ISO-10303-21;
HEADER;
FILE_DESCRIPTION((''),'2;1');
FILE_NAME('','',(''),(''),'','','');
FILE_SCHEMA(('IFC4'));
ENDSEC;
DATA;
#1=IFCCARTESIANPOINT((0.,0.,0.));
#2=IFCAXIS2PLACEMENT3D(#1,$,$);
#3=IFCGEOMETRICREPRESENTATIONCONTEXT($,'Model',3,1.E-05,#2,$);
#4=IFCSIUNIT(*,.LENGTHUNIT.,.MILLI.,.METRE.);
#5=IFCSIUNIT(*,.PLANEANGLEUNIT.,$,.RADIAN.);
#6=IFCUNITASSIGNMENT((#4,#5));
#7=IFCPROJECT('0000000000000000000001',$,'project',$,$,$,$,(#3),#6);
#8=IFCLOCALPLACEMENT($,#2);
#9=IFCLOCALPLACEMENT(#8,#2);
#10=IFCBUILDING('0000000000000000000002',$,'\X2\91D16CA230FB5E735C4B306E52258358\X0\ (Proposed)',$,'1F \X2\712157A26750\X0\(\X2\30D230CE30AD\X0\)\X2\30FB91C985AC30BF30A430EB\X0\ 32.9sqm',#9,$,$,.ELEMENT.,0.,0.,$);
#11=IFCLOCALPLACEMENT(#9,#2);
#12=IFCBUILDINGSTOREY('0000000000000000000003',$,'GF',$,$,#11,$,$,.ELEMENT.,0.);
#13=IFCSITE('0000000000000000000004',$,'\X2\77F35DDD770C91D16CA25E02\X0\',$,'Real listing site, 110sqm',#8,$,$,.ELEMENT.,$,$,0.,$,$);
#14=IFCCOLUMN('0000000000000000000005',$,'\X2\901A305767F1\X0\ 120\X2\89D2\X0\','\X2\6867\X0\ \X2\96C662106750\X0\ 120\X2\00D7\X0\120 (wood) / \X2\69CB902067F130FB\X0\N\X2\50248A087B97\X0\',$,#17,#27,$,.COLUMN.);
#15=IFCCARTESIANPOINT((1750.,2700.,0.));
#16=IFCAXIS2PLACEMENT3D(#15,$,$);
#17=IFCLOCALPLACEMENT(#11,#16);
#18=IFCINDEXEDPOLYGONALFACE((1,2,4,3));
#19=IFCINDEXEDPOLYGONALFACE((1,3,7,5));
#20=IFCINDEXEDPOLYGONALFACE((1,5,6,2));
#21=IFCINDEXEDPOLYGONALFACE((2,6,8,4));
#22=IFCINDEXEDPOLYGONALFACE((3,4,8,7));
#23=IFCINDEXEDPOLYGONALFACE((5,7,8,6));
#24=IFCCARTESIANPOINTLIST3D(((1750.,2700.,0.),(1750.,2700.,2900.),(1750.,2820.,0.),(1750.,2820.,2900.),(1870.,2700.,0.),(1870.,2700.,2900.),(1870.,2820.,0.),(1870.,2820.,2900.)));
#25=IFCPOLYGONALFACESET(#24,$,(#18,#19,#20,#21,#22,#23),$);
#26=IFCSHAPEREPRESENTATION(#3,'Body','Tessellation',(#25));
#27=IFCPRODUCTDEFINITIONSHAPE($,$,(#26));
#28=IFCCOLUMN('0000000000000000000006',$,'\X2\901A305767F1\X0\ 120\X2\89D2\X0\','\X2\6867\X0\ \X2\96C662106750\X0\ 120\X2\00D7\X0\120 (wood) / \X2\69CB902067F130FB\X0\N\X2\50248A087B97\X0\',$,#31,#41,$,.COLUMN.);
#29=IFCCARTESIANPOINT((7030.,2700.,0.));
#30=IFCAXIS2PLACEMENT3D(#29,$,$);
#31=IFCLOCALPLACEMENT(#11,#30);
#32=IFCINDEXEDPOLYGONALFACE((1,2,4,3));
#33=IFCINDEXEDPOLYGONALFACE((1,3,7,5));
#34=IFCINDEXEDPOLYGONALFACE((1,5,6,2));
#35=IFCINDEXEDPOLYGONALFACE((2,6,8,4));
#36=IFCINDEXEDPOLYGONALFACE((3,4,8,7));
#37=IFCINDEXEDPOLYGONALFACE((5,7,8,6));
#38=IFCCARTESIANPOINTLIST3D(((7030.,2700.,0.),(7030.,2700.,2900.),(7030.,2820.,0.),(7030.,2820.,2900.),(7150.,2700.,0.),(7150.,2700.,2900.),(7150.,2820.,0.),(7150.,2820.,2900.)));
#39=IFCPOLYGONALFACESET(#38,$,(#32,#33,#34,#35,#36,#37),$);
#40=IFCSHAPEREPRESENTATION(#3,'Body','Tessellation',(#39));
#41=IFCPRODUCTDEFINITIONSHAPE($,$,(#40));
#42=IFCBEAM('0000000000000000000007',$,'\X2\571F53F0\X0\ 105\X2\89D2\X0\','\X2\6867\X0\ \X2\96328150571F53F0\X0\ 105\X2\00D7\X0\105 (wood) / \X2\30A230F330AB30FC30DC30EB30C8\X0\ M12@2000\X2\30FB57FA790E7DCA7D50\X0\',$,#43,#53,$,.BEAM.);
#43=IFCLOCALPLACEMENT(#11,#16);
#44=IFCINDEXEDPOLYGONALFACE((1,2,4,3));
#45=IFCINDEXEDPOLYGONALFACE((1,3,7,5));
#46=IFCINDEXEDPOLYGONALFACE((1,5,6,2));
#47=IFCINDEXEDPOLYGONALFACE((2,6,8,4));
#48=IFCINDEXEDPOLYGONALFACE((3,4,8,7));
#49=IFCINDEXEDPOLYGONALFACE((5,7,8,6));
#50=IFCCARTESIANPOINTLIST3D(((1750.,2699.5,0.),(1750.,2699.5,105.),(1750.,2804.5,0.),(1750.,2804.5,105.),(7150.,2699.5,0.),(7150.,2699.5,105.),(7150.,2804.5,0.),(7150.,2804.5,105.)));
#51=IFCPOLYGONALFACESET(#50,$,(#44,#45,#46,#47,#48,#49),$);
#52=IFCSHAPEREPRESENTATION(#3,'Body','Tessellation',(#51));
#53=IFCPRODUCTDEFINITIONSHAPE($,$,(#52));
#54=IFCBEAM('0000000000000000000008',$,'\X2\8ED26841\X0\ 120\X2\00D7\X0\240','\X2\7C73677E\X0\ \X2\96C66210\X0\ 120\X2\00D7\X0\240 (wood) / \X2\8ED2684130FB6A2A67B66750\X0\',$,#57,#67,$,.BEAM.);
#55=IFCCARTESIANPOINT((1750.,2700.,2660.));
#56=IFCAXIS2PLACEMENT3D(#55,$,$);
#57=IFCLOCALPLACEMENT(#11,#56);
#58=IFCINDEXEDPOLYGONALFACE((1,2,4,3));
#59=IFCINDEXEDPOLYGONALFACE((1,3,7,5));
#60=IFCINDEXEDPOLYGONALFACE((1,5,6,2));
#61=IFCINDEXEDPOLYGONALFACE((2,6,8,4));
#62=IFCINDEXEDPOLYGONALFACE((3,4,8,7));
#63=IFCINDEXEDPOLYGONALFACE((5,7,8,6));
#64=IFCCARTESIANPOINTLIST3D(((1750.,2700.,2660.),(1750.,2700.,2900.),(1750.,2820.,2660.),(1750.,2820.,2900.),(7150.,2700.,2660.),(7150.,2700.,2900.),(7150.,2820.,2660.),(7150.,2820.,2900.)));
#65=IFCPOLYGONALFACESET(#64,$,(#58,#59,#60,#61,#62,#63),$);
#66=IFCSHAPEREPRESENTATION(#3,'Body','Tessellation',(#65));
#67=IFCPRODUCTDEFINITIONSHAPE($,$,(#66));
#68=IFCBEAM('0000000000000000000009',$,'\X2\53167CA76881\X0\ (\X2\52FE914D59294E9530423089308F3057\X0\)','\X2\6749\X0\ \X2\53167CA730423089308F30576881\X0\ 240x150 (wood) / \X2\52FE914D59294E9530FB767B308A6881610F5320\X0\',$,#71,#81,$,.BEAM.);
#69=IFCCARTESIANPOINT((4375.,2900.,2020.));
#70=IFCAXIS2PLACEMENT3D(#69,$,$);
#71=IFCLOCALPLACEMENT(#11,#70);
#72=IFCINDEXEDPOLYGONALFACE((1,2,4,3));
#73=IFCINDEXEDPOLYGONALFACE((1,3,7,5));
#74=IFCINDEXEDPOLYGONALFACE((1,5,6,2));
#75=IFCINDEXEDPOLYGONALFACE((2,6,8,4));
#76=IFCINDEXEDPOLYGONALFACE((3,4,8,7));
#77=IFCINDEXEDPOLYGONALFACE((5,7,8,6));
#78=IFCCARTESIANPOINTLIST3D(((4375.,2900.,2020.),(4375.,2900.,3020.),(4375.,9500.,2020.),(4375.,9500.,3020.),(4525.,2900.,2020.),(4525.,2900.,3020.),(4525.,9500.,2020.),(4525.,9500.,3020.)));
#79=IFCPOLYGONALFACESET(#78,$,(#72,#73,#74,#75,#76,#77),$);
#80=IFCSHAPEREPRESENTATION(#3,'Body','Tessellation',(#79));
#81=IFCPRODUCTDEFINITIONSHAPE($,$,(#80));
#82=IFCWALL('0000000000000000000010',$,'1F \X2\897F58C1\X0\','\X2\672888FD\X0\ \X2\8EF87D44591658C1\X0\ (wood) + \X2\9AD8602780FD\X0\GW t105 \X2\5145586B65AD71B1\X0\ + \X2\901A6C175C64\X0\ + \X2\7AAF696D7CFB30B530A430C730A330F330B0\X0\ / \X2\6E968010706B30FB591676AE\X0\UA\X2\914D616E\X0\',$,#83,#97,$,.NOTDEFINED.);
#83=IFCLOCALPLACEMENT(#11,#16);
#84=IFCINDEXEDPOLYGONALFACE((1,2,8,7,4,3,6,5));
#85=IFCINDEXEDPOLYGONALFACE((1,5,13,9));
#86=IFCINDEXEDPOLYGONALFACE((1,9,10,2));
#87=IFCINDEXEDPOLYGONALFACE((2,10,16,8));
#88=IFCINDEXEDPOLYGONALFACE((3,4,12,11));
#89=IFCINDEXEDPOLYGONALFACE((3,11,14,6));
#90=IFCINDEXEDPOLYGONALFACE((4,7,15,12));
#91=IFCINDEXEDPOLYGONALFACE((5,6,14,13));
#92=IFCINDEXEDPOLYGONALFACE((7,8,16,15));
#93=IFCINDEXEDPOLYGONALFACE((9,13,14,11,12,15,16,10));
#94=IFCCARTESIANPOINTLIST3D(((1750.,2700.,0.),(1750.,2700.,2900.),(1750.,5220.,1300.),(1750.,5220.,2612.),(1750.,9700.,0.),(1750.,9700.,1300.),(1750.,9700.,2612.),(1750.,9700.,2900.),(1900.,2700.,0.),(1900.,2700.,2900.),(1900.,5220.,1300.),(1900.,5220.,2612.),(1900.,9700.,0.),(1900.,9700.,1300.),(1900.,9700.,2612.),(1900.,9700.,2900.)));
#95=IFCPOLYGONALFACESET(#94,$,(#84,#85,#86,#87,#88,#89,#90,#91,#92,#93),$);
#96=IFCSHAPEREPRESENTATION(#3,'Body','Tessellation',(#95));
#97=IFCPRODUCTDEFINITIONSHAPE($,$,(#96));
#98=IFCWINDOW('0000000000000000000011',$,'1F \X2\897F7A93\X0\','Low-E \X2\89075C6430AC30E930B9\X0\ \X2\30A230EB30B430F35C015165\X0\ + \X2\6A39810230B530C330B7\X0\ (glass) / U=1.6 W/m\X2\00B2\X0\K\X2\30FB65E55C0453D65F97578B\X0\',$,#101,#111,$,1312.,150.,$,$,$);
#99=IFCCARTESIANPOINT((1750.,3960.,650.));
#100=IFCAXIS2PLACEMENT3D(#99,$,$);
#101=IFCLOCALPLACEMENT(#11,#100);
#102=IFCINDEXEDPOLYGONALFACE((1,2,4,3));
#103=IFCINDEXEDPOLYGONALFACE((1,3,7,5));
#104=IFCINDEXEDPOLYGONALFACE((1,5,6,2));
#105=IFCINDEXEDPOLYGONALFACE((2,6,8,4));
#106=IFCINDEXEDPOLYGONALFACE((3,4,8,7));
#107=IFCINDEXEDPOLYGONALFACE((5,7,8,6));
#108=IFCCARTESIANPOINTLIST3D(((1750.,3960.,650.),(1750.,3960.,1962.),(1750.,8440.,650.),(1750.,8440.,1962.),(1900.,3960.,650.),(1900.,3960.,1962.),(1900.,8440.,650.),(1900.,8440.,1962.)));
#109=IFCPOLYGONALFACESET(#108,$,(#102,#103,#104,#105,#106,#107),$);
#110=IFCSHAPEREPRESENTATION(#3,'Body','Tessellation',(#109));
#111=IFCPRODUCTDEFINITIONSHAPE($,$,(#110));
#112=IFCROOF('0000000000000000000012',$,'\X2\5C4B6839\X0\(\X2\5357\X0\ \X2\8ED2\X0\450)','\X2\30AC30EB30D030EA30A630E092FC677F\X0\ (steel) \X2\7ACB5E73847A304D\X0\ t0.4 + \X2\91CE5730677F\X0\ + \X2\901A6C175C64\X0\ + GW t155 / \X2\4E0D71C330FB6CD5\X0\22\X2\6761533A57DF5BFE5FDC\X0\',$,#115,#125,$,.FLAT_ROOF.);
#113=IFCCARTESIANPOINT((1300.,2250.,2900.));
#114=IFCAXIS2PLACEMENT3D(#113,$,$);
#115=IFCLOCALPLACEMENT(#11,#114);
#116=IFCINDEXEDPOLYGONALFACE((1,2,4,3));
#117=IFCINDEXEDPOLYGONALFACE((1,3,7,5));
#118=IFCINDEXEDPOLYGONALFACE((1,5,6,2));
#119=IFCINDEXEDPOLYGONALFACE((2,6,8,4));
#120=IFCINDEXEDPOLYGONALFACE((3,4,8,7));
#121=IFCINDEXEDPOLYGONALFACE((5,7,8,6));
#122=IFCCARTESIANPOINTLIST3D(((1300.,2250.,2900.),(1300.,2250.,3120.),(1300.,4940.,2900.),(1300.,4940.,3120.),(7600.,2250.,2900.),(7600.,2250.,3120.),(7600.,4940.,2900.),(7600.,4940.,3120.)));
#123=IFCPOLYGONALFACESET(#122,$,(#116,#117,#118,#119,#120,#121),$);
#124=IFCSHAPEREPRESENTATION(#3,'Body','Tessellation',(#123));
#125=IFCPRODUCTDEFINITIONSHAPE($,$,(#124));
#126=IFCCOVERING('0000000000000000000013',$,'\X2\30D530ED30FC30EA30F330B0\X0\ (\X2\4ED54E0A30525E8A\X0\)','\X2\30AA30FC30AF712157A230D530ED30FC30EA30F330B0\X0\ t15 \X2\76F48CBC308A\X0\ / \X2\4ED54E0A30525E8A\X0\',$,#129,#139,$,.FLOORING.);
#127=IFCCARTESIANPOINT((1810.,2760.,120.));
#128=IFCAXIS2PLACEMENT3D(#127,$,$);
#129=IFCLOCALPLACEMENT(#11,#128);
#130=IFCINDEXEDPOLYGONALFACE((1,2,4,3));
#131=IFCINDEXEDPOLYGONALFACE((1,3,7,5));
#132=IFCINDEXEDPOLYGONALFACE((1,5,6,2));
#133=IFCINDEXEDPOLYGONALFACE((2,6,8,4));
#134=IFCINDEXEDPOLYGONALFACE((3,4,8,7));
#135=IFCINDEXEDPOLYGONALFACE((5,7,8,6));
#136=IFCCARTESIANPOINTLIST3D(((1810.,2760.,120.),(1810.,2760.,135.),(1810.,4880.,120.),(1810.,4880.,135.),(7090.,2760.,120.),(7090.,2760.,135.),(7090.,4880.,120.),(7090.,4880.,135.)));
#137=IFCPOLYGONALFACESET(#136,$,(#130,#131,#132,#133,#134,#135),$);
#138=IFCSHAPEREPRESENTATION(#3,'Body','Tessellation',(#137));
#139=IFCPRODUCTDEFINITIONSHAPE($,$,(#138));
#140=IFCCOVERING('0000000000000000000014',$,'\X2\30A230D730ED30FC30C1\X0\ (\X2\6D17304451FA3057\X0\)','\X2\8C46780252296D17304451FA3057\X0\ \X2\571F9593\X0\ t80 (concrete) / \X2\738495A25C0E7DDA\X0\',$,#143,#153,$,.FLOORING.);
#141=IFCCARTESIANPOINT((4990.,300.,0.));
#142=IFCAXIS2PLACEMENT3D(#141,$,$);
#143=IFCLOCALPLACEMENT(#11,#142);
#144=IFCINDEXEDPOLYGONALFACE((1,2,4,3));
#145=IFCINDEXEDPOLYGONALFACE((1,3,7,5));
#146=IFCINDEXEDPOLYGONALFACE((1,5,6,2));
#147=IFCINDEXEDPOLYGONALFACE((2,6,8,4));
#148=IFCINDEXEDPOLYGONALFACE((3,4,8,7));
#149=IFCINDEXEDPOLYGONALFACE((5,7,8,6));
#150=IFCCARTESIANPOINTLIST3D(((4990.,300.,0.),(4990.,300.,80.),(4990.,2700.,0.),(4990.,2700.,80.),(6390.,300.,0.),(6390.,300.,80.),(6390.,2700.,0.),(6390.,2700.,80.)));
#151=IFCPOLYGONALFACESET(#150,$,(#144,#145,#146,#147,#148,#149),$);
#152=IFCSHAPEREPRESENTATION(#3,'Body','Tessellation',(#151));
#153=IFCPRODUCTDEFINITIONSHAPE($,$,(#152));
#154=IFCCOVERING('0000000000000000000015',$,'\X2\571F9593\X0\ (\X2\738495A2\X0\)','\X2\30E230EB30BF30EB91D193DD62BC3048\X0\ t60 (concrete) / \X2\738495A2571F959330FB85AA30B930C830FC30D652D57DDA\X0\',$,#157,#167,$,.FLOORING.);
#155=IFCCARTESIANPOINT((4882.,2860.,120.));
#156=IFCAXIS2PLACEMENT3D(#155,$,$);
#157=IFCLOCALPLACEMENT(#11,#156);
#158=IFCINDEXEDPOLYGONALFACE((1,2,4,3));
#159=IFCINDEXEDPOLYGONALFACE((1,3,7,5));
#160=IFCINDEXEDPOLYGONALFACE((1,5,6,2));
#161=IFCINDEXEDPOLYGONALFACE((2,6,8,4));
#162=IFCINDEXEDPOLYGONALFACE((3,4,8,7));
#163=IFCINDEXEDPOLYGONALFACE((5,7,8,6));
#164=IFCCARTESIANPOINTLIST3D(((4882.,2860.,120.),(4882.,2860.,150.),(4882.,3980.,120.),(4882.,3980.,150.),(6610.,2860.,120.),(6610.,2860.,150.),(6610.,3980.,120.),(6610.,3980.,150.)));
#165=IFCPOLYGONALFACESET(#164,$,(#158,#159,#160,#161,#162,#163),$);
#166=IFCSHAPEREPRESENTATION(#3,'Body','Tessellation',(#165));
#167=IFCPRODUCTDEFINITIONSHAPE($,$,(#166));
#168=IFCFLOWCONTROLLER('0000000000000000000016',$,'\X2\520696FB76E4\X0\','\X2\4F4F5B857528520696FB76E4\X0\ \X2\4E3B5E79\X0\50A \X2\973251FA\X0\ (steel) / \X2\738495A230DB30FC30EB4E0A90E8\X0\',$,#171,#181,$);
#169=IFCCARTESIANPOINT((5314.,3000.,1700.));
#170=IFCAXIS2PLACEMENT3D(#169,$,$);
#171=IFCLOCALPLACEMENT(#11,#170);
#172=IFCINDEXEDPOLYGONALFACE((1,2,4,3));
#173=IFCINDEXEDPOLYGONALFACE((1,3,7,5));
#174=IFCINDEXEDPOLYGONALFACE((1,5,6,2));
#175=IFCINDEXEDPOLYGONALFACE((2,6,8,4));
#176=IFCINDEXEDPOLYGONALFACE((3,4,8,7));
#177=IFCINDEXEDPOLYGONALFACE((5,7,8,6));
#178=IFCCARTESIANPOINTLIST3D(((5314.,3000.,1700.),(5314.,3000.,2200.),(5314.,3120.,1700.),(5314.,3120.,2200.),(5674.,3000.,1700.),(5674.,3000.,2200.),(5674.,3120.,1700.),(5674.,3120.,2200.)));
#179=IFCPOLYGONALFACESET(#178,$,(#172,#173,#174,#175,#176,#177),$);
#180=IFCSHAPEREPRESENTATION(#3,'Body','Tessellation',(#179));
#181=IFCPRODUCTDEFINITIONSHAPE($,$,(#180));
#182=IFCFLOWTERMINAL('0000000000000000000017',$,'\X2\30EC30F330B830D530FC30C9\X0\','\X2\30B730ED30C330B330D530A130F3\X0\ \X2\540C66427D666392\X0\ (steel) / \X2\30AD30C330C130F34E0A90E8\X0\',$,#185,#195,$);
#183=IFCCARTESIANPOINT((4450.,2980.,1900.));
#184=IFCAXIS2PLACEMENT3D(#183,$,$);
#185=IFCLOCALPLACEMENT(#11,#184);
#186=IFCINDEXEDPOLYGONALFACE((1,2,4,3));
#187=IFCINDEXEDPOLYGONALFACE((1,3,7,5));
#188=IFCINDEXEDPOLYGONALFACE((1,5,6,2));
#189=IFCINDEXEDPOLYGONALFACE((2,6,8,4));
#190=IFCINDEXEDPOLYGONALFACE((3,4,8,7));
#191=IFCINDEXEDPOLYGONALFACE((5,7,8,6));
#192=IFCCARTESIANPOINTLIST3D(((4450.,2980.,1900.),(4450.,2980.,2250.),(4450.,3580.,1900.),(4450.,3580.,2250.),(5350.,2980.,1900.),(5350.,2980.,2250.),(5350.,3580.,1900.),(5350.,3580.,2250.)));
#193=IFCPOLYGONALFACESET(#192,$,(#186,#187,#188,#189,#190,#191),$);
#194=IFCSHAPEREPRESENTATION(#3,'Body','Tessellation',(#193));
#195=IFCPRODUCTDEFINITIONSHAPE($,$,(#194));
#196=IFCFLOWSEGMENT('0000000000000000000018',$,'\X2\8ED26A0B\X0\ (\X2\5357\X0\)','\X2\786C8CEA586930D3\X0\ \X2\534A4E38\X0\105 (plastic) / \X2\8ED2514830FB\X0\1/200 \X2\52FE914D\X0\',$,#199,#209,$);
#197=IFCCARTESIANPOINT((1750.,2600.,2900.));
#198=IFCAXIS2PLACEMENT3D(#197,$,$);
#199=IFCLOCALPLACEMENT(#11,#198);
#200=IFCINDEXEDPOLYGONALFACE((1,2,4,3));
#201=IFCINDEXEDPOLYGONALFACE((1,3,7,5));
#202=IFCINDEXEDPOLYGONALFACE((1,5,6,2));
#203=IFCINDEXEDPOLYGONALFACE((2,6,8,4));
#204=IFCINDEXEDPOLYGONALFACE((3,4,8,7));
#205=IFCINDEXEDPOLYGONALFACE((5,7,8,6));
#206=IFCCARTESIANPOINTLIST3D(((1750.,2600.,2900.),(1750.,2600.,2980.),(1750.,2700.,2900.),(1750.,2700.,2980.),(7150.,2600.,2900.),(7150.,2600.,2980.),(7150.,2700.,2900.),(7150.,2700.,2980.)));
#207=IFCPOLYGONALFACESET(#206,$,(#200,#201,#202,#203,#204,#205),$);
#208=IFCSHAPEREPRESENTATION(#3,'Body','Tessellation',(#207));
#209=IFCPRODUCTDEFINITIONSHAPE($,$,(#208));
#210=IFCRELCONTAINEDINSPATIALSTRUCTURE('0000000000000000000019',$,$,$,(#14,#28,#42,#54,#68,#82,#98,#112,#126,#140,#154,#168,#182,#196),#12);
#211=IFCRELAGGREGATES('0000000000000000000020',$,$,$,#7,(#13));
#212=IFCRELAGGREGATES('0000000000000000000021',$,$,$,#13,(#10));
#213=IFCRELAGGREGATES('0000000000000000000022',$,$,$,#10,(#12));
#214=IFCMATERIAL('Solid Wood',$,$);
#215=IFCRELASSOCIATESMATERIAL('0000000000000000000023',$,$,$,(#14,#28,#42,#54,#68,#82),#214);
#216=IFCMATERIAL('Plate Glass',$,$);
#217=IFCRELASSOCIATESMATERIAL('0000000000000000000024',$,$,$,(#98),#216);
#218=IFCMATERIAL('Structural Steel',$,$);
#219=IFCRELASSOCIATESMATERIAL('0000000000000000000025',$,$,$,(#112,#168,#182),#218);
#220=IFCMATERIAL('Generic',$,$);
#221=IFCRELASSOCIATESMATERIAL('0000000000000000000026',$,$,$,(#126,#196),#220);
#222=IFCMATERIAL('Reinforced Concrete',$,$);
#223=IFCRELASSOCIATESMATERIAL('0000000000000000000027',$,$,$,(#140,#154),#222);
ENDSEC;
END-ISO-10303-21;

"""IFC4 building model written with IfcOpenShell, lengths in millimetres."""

from ifc_helpers import new_model, si_unit, frame, frame_2d, origin, place, context, project, spatial, rectangle, extrude, material, element, fill, save


model = new_model("IFC4")

# Units and contexts
model_context = context("Model", 3, precision=1e-05, world=origin())
ifc_project = project(units=[si_unit("LENGTHUNIT", "METRE", prefix="MILLI"), si_unit("PLANEANGLEUNIT", "RADIAN")], contexts=[model_context])

# Site, building, storey
site_placement = place(None, origin())
site = spatial("IfcSite", under=ifc_project, at=site_placement, Name="石川県金沢市", ObjectType="Real listing site, 110sqm", CompositionType="ELEMENT", RefElevation=0.0)
building_placement = place(site_placement, origin())
building = spatial("IfcBuilding", under=site, at=building_placement, Name="金沢・平屋の別荘 (Proposed)", ObjectType="1F 無垢材(ヒノキ)・釉薬タイル 32.9sqm", CompositionType="ELEMENT", ElevationOfRefHeight=0.0, ElevationOfTerrain=0.0)
storey_placement = place(building_placement, origin())
storey = spatial("IfcBuildingStorey", under=building, at=storey_placement, Name="GF", CompositionType="ELEMENT", Elevation=0.0)

# Columns
ifc_material_1 = material(Name="Solid Wood")
column_1_placement = place(storey_placement, frame((1750.0, 2700.0, 0.0)))
element("IfcColumn", 1, at=column_1_placement, inside=storey, material=ifc_material_1, Name="通し柱 120角", Description="桧 集成材 120×120 (wood) / 構造柱・N値計算", PredefinedType="COLUMN", context=model_context, shape_type="SweptSolid", body=[
    extrude(rectangle(XDim=120.0, YDim=120.0, at=frame_2d((60.0, 60.0))), frame((1750.0, 2700.0, 0.0)), (0.0, 0.0, 1.0), 2900.0),
])
column_2_placement = place(storey_placement, frame((7030.0, 2700.0, 0.0)))
element("IfcColumn", 2, at=column_2_placement, inside=storey, material=ifc_material_1, Name="通し柱 120角", Description="桧 集成材 120×120 (wood) / 構造柱・N値計算", PredefinedType="COLUMN", context=model_context, shape_type="SweptSolid", body=[
    extrude(rectangle(XDim=120.0, YDim=120.0, at=frame_2d((60.0, 60.0))), frame((7030.0, 2700.0, 0.0)), (0.0, 0.0, 1.0), 2900.0),
])

# Beams
beam_1_placement = place(storey_placement, frame((1750.0, 2700.0, 0.0)))
element("IfcBeam", 3, at=beam_1_placement, inside=storey, material=ifc_material_1, Name="土台 105角", Description="桧 防腐土台 105×105 (wood) / アンカーボルト M12@2000・基礎緊結", PredefinedType="BEAM", context=model_context, shape_type="SweptSolid", body=[
    extrude(rectangle(XDim=5400.0, YDim=105.0, at=frame_2d((2700.0, 52.0))), frame((1750.0, 2700.0, 0.0)), (0.0, 0.0, 1.0), 105.0),
])
beam_2_placement = place(storey_placement, frame((1750.0, 2700.0, 2660.0)))
element("IfcBeam", 4, at=beam_2_placement, inside=storey, material=ifc_material_1, Name="軒桁 120×240", Description="米松 集成 120×240 (wood) / 軒桁・横架材", PredefinedType="BEAM", context=model_context, shape_type="SweptSolid", body=[
    extrude(rectangle(XDim=5400.0, YDim=120.0, at=frame_2d((2700.0, 60.0))), frame((1750.0, 2700.0, 2660.0)), (0.0, 0.0, 1.0), 240.0),
])
beam_3_placement = place(storey_placement, frame((4375.0, 2900.0, 2020.0)))
element("IfcBeam", 5, at=beam_3_placement, inside=storey, material=ifc_material_1, Name="化粧梁 (勾配天井あらわし)", Description="杉 化粧あらわし梁 240x150 (wood) / 勾配天井・登り梁意匠", PredefinedType="BEAM", context=model_context, shape_type="SweptSolid", body=[
    extrude(rectangle(XDim=150.0, YDim=6600.0, at=frame_2d((75.0, 3300.0))), frame((4375.0, 2900.0, 2020.0)), (0.0, 0.0, 1.0), 1000.0),
])

# Shared definitions
ifc_material_2 = material(Name="Reinforced Concrete")

# Shared definitions
ifc_material_3 = material(Name="Plate Glass")

# Wall, opening, window
wall_1_placement = place(storey_placement, frame((1750.0, 2700.0, 0.0)))
wall_1 = element("IfcWall", 6, at=wall_1_placement, inside=storey, material=ifc_material_1, Name="1F 西壁", Description="木製 軸組外壁 (wood) + 高性能GW t105 充填断熱 + 通気層 + 窯業系サイディング / 準耐火・外皮UA配慮", PredefinedType="NOTDEFINED", context=model_context, shape_type="SweptSolid", body=[
    extrude(rectangle(XDim=150.0, YDim=7000.0, at=frame_2d((75.0, 3500.0))), frame((1750.0, 2700.0, 0.0)), (0.0, 0.0, 1.0), 2900.0),
])
opening_1_placement = place(storey_placement, frame((1750.0, 3960.0, 650.0)))
opening_1 = element("IfcOpeningElement", 7, at=opening_1_placement, cuts=wall_1, PredefinedType="NOTDEFINED", context=model_context, shape_type="SweptSolid", body=[
    extrude(rectangle(XDim=150.0, YDim=4480.0, at=frame_2d((75.0, 2240.0))), frame((1750.0, 3960.0, 650.0)), (0.0, 0.0, 1.0), 1312.0),
])
window_1_placement = place(storey_placement, frame((1750.0, 3960.0, 650.0)))
window_1 = element("IfcWindow", 8, at=window_1_placement, inside=storey, material=ifc_material_3, Name="1F 西窓", Description="Low-E 複層ガラス アルゴン封入 + 樹脂サッシ (glass) / U=1.6 W/m²K・日射取得型", OverallHeight=1312.0, OverallWidth=150.0, context=model_context, shape_type="SweptSolid", body=[
    extrude(rectangle(XDim=150.0, YDim=4480.0, at=frame_2d((75.0, 2240.0))), frame((1750.0, 3960.0, 650.0)), (0.0, 0.0, 1.0), 1312.0),
])
fill(opening_1, window_1)

# Roof
ifc_material_4 = material(Name="Structural Steel")
roof_placement = place(storey_placement, frame((1300.0, 2250.0, 2900.0)))
element("IfcRoof", 9, at=roof_placement, inside=storey, material=ifc_material_4, Name="屋根(南 軒450)", Description="ガルバリウム鋼板 (steel) 立平葺き t0.4 + 野地板 + 通気層 + GW t155 / 不燃・法22条区域対応", PredefinedType="FLAT_ROOF", context=model_context, shape_type="SweptSolid", body=[
    extrude(rectangle(XDim=6300.0, YDim=2690.0, at=frame_2d((3150.0, 1345.0))), frame((1300.0, 2250.0, 2900.0)), (0.0, 0.0, 1.0), 220.0),
])

# Coverings
ifc_material_5 = material(Name="Generic")
covering_1_placement = place(storey_placement, frame((1810.0, 2760.0, 120.0)))
element("IfcCovering", 10, at=covering_1_placement, inside=storey, material=ifc_material_5, Name="フローリング (仕上げ床)", Description="オーク無垢フローリング t15 直貼り / 仕上げ床", PredefinedType="FLOORING", context=model_context, shape_type="SweptSolid", body=[
    extrude(rectangle(XDim=5280.0, YDim=2120.0, at=frame_2d((2640.0, 1060.0))), frame((1810.0, 2760.0, 120.0)), (0.0, 0.0, 1.0), 15.0),
])
covering_2_placement = place(storey_placement, frame((4990.0, 300.0, 0.0)))
element("IfcCovering", 11, at=covering_2_placement, inside=storey, material=ifc_material_2, Name="アプローチ (洗い出し)", Description="豆砂利洗い出し 土間 t80 (concrete) / 玄関導線", PredefinedType="FLOORING", context=model_context, shape_type="SweptSolid", body=[
    extrude(rectangle(XDim=1400.0, YDim=2400.0, at=frame_2d((700.0, 1200.0))), frame((4990.0, 300.0, 0.0)), (0.0, 0.0, 1.0), 80.0),
])
covering_3_placement = place(storey_placement, frame((4882.0, 2860.0, 120.0)))
element("IfcCovering", 12, at=covering_3_placement, inside=storey, material=ifc_material_2, Name="土間 (玄関)", Description="モルタル金鏝押え t60 (concrete) / 玄関土間・薪ストーブ動線", PredefinedType="FLOORING", context=model_context, shape_type="SweptSolid", body=[
    extrude(rectangle(XDim=1728.0, YDim=1120.0, at=frame_2d((864.0, 560.0))), frame((4882.0, 2860.0, 120.0)), (0.0, 0.0, 1.0), 30.0),
])

# Flow controller
flow_controller_placement = place(storey_placement, frame((5314.0, 3000.0, 1700.0)))
element("IfcFlowController", 13, at=flow_controller_placement, inside=storey, material=ifc_material_4, Name="分電盤", Description="住宅用分電盤 主幹50A 露出 (steel) / 玄関ホール上部", context=model_context, shape_type="SweptSolid", body=[
    extrude(rectangle(XDim=360.0, YDim=120.0, at=frame_2d((180.0, 60.0))), frame((5314.0, 3000.0, 1700.0)), (0.0, 0.0, 1.0), 500.0),
])

# Flow terminal
flow_terminal_placement = place(storey_placement, frame((4450.0, 2980.0, 1900.0)))
element("IfcFlowTerminal", 14, at=flow_terminal_placement, inside=storey, material=ifc_material_4, Name="レンジフード", Description="シロッコファン 同時給排 (steel) / キッチン上部", context=model_context, shape_type="SweptSolid", body=[
    extrude(rectangle(XDim=900.0, YDim=600.0, at=frame_2d((450.0, 300.0))), frame((4450.0, 2980.0, 1900.0)), (0.0, 0.0, 1.0), 350.0),
])

# Flow segment
flow_segment_1_placement = place(storey_placement, frame((1750.0, 2600.0, 2900.0)))
element("IfcFlowSegment", 15, at=flow_segment_1_placement, inside=storey, material=ifc_material_5, Name="軒樋 (南)", Description="硬質塩ビ 半丸105 (plastic) / 軒先・1/200 勾配", context=model_context, shape_type="SweptSolid", body=[
    extrude(rectangle(XDim=5400.0, YDim=100.0, at=frame_2d((2700.0, 50.0))), frame((1750.0, 2600.0, 2900.0)), (0.0, 0.0, 1.0), 80.0),
])

save(model, "model.ifc")
